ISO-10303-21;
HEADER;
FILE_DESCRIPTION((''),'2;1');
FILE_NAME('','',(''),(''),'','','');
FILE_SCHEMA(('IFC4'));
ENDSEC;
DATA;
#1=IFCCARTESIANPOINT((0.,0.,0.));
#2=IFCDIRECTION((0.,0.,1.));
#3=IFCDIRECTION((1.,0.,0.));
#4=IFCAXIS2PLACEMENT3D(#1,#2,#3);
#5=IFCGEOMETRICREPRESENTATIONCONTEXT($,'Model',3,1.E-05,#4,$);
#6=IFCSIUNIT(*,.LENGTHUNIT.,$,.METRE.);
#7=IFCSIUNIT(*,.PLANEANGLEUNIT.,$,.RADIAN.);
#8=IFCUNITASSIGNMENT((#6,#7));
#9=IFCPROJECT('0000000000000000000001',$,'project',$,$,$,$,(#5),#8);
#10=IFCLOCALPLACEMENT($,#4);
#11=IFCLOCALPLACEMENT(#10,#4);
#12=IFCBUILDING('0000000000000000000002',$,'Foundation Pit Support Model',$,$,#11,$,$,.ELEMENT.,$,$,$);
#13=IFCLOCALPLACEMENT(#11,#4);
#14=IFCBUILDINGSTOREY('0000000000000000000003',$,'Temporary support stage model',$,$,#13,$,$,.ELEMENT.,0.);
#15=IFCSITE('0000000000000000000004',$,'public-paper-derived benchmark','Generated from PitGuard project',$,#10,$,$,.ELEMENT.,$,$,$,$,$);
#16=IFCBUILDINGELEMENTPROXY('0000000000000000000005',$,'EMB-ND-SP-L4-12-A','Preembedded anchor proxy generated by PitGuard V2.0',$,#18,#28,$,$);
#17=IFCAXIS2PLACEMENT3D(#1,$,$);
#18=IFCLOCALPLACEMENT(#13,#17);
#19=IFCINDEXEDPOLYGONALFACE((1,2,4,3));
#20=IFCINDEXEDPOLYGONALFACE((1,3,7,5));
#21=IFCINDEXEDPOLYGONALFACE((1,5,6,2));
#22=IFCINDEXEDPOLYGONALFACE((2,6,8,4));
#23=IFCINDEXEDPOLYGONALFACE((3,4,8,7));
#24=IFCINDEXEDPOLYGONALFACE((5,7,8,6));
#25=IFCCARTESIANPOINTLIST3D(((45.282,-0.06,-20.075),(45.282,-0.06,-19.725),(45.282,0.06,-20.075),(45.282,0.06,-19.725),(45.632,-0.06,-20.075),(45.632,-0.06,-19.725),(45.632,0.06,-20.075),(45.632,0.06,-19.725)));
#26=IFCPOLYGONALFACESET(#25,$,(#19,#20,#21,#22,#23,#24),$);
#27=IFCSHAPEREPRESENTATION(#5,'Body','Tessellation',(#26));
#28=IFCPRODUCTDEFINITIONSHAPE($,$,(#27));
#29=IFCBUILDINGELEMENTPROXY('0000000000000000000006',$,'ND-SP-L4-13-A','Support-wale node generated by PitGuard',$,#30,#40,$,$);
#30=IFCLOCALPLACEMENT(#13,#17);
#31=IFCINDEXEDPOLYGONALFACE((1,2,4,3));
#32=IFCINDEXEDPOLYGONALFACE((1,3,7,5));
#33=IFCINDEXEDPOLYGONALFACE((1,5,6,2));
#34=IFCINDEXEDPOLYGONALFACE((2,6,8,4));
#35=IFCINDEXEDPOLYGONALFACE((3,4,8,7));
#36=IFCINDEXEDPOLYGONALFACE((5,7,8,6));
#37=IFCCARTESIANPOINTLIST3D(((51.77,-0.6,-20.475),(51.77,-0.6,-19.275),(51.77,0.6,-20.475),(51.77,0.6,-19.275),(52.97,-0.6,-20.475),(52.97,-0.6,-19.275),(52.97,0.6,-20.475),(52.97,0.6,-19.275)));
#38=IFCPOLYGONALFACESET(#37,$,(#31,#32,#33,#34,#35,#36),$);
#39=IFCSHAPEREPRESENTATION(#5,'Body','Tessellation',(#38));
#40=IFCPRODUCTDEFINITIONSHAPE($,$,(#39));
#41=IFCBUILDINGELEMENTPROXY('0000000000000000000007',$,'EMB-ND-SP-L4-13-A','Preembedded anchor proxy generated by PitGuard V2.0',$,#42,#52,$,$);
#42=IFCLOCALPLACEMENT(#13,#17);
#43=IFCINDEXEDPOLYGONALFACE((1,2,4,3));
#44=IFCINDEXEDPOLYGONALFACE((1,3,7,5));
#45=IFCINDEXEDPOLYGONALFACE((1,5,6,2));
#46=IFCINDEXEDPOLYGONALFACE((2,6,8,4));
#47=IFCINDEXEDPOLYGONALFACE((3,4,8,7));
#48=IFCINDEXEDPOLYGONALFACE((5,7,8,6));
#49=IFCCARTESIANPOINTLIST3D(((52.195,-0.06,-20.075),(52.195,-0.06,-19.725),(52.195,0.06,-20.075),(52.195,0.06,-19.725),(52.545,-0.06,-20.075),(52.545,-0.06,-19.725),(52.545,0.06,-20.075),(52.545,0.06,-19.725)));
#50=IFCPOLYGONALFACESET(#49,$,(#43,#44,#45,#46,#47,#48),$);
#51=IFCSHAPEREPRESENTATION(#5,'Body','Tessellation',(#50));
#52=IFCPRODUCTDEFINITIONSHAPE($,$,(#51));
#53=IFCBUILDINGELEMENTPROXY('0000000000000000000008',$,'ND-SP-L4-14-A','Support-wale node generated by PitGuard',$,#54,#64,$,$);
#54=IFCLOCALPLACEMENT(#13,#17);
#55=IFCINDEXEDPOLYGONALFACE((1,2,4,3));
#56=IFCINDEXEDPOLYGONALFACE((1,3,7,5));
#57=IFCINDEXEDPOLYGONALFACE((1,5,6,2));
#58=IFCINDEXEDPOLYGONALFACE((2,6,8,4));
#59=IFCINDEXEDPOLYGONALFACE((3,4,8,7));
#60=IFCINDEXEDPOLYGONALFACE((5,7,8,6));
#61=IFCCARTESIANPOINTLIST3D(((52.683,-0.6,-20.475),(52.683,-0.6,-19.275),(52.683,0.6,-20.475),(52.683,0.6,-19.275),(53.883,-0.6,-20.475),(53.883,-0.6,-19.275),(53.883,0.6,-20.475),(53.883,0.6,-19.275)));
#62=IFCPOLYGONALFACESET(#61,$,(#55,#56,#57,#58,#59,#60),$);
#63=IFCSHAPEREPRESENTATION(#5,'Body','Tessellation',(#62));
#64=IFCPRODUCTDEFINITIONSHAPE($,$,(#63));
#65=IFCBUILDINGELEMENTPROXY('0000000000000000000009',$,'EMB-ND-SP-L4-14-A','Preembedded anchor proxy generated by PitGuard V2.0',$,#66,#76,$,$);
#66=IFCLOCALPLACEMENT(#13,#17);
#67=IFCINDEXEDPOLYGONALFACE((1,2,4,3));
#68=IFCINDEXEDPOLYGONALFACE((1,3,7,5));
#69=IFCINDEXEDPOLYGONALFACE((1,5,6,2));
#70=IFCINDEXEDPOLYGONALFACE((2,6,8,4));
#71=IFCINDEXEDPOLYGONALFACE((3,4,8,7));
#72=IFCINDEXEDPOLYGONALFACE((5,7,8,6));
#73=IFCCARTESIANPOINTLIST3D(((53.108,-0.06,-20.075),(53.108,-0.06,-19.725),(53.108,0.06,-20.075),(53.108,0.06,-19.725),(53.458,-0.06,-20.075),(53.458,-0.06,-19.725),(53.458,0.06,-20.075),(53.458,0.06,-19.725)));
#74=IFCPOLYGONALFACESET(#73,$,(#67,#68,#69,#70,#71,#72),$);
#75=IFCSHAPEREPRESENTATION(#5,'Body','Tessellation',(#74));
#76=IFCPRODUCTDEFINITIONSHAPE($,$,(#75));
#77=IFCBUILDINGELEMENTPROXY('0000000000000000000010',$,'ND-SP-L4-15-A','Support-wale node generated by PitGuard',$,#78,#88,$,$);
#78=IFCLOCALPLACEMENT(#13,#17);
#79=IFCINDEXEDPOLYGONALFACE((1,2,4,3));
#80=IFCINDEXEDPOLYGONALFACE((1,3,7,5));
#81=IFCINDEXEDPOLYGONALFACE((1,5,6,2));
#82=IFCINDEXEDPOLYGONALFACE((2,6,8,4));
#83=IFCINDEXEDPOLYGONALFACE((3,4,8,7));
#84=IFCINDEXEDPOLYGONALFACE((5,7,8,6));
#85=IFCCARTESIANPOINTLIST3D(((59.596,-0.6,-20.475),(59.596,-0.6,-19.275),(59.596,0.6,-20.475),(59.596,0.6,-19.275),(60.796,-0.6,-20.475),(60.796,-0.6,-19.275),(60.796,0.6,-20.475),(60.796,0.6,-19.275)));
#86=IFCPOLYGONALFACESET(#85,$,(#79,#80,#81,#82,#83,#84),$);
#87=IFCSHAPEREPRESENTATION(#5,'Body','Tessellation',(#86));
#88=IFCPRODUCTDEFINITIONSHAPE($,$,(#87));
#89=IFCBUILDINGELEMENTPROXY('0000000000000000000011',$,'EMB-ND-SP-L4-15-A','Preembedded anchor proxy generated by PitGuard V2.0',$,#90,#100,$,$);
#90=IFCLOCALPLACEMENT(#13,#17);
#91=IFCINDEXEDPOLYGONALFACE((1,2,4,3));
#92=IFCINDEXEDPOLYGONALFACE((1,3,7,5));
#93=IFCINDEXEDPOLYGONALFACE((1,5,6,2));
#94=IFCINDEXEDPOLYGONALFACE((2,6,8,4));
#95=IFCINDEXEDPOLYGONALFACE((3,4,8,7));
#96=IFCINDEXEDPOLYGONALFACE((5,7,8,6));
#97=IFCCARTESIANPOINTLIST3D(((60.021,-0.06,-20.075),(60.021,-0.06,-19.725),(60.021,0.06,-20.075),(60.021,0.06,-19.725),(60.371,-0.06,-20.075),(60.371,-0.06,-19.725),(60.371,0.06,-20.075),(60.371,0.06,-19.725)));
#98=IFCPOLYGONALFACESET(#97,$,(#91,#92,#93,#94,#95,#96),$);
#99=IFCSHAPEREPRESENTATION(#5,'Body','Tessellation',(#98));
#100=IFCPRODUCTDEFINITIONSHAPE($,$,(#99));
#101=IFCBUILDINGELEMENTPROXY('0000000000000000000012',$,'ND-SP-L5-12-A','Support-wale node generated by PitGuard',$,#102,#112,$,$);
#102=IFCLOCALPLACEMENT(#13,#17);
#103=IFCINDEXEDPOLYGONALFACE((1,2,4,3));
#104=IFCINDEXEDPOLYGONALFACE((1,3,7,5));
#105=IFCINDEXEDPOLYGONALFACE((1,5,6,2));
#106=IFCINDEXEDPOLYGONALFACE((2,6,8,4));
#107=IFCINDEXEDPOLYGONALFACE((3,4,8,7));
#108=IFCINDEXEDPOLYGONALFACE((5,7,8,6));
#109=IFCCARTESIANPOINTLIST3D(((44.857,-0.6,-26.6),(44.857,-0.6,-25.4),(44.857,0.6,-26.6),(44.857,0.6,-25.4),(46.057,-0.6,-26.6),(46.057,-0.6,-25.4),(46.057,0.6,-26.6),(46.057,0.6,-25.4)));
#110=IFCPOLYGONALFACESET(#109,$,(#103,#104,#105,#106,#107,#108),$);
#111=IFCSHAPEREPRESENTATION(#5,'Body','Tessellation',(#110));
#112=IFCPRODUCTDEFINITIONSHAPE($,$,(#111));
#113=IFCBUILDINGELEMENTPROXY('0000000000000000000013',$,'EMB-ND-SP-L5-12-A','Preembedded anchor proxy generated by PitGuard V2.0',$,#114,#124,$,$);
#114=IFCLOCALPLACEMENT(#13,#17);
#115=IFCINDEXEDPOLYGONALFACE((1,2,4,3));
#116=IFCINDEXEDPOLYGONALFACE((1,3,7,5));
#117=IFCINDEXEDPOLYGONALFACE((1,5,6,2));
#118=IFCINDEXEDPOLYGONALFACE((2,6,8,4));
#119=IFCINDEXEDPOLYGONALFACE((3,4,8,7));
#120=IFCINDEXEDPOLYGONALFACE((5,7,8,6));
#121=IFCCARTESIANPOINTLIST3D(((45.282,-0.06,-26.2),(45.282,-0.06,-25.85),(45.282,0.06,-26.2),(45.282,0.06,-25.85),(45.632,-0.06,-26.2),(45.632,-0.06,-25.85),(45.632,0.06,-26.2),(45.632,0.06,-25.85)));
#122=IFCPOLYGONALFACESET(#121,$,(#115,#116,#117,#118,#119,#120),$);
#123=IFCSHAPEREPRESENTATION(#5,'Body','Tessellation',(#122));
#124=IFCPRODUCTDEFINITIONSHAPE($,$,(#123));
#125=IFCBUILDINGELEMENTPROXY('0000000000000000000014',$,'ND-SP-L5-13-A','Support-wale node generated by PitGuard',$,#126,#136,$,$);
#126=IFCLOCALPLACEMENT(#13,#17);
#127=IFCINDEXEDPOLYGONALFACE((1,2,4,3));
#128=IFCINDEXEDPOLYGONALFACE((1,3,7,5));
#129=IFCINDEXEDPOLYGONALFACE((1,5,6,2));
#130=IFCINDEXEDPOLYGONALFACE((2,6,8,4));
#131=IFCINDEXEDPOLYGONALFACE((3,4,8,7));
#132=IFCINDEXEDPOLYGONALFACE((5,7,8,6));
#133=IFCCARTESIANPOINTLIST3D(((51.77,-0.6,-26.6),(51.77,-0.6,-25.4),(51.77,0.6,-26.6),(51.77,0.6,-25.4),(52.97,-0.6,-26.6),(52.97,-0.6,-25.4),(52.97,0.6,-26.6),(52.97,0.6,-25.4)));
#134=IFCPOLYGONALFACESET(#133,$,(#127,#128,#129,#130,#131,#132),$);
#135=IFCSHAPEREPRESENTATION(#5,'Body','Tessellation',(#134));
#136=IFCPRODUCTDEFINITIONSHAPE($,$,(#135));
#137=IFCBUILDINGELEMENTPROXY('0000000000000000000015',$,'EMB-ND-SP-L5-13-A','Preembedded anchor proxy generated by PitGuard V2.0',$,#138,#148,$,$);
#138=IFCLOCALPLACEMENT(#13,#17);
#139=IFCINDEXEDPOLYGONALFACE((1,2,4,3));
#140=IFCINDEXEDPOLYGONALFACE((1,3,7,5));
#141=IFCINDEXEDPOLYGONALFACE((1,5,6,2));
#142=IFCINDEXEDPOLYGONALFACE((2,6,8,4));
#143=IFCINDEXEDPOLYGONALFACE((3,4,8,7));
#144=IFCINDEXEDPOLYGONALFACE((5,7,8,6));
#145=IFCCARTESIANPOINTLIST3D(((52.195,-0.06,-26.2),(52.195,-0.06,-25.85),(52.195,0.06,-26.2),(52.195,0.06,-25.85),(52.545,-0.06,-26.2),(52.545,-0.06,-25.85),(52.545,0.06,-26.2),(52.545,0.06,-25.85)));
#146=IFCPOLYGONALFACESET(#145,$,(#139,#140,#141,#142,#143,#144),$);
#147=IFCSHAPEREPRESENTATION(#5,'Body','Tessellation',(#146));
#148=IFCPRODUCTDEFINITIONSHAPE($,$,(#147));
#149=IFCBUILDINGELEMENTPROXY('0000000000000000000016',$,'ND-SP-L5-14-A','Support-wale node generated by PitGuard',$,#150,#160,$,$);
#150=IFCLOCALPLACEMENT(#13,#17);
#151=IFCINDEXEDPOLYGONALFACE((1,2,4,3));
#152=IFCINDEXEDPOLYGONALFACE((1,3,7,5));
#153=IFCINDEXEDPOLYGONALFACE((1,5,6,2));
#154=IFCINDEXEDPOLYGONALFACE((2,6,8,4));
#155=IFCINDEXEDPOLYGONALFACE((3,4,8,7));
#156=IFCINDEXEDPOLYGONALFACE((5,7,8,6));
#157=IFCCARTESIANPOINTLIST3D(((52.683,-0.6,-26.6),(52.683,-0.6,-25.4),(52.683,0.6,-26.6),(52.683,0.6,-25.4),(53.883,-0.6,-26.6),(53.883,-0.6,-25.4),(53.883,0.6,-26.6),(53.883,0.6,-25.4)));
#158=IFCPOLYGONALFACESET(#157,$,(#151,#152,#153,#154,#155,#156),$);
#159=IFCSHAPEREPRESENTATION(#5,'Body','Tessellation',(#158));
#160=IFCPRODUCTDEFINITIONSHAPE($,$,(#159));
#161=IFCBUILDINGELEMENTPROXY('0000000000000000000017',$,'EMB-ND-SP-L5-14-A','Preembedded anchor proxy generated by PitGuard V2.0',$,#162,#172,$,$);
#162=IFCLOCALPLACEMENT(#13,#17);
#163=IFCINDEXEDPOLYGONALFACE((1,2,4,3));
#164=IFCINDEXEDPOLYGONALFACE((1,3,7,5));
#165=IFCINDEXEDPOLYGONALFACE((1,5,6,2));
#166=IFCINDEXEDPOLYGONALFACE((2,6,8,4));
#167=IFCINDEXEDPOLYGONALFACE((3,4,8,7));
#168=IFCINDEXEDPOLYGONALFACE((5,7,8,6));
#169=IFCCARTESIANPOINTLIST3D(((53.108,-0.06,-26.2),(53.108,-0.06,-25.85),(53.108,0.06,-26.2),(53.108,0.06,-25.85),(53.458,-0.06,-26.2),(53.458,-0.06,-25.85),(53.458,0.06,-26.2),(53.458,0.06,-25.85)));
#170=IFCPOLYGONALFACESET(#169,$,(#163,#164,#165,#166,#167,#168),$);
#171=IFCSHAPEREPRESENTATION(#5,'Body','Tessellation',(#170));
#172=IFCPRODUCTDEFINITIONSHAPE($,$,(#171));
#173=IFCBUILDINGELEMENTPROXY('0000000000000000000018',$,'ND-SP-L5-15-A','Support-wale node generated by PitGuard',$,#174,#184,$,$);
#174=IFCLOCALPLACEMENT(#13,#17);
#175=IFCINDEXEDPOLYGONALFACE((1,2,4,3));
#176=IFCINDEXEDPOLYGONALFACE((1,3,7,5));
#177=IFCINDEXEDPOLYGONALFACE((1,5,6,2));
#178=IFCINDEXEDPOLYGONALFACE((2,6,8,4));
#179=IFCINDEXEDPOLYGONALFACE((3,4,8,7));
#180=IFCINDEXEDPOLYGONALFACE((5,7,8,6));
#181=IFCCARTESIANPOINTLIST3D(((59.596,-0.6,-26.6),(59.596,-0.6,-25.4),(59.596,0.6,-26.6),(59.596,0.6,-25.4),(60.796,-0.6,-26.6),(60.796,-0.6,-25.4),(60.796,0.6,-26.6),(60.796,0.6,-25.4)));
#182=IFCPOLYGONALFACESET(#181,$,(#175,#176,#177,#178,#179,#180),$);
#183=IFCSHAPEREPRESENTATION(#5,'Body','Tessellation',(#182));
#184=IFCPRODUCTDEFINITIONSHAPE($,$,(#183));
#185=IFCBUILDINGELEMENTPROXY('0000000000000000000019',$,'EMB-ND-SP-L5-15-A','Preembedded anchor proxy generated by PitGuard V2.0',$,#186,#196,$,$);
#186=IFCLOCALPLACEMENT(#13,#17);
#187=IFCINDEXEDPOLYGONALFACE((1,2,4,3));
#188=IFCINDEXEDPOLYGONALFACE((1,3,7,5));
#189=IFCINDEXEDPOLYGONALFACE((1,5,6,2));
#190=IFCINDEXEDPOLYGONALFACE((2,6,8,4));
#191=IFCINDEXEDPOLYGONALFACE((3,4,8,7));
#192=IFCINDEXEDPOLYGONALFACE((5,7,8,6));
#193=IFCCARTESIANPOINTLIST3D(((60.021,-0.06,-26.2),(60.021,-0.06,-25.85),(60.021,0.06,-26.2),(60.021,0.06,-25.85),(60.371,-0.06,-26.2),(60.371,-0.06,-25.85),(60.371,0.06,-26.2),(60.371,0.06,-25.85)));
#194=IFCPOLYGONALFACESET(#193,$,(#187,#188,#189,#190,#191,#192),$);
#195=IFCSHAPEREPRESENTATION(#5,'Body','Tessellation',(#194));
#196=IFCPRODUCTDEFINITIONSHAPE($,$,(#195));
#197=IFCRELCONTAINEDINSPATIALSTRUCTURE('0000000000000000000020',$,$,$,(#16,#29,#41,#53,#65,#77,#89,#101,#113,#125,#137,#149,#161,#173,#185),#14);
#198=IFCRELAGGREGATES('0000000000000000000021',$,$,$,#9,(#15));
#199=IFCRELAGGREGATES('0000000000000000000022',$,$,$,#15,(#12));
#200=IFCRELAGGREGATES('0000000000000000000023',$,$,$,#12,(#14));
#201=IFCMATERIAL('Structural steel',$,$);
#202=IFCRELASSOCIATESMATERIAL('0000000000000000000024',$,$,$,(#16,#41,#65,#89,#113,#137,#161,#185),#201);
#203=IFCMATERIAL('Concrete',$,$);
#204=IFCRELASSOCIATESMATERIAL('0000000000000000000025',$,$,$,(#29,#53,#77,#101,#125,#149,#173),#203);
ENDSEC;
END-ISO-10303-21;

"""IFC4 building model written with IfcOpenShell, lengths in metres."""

from ifc_helpers import new_model, si_unit, frame, origin_with_axes, origin_2d, place, context, project, spatial, rectangle, extrude, material, element, save


model = new_model("IFC4")

# Units and contexts
model_context = context("Model", 3, precision=1e-05, world=origin_with_axes())
ifc_project = project(units=[si_unit("LENGTHUNIT", "METRE"), si_unit("PLANEANGLEUNIT", "RADIAN")], contexts=[model_context])

# Site, building, storey
site_placement = place(None, origin_with_axes())
site = spatial("IfcSite", under=ifc_project, at=site_placement, Name="public-paper-derived benchmark", Description="Generated from PitGuard project", CompositionType="ELEMENT")
building_placement = place(site_placement, origin_with_axes())
building = spatial("IfcBuilding", under=site, at=building_placement, Name="Foundation Pit Support Model", CompositionType="ELEMENT")
storey_placement = place(building_placement, origin_with_axes())
storey = spatial("IfcBuildingStorey", under=building, at=storey_placement, Name="Temporary support stage model", CompositionType="ELEMENT", Elevation=0.0)

# Shared definitions
ifc_material_1 = material(Name="Structural steel")

# Shared definitions
ifc_material_2 = material(Name="Concrete")

# Building element proxies
proxy_1_placement = place(storey_placement, frame((45.457, 0.0, -20.075), z_axis=(0.0, 0.0, 1.0), x_axis=(1.0, 0.0, 0.0)))
element("IfcBuildingElementProxy", 1, at=proxy_1_placement, inside=storey, material=ifc_material_1, Name="EMB-ND-SP-L4-12-A", Description="Preembedded anchor proxy generated by PitGuard V2.0", context=model_context, shape_type="SweptSolid", body=[
    extrude(rectangle(XDim=0.35, YDim=0.12, at=origin_2d()), origin_with_axes(), (0.0, 0.0, 1.0), 0.35),
])
proxy_2_placement = place(storey_placement, frame((52.37, 0.0, -20.475), z_axis=(0.0, 0.0, 1.0), x_axis=(1.0, 0.0, 0.0)))
element("IfcBuildingElementProxy", 2, at=proxy_2_placement, inside=storey, material=ifc_material_2, Name="ND-SP-L4-13-A", Description="Support-wale node generated by PitGuard", context=model_context, shape_type="SweptSolid", body=[
    extrude(rectangle(XDim=1.2, YDim=1.2, at=origin_2d()), origin_with_axes(), (0.0, 0.0, 1.0), 1.2),
])
proxy_3_placement = place(storey_placement, frame((52.37, 0.0, -20.075), z_axis=(0.0, 0.0, 1.0), x_axis=(1.0, 0.0, 0.0)))
element("IfcBuildingElementProxy", 3, at=proxy_3_placement, inside=storey, material=ifc_material_1, Name="EMB-ND-SP-L4-13-A", Description="Preembedded anchor proxy generated by PitGuard V2.0", context=model_context, shape_type="SweptSolid", body=[
    extrude(rectangle(XDim=0.35, YDim=0.12, at=origin_2d()), origin_with_axes(), (0.0, 0.0, 1.0), 0.35),
])
proxy_4_placement = place(storey_placement, frame((53.283, 0.0, -20.475), z_axis=(0.0, 0.0, 1.0), x_axis=(1.0, 0.0, 0.0)))
element("IfcBuildingElementProxy", 4, at=proxy_4_placement, inside=storey, material=ifc_material_2, Name="ND-SP-L4-14-A", Description="Support-wale node generated by PitGuard", context=model_context, shape_type="SweptSolid", body=[
    extrude(rectangle(XDim=1.2, YDim=1.2, at=origin_2d()), origin_with_axes(), (0.0, 0.0, 1.0), 1.2),
])
proxy_5_placement = place(storey_placement, frame((53.283, 0.0, -20.075), z_axis=(0.0, 0.0, 1.0), x_axis=(1.0, 0.0, 0.0)))
element("IfcBuildingElementProxy", 5, at=proxy_5_placement, inside=storey, material=ifc_material_1, Name="EMB-ND-SP-L4-14-A", Description="Preembedded anchor proxy generated by PitGuard V2.0", context=model_context, shape_type="SweptSolid", body=[
    extrude(rectangle(XDim=0.35, YDim=0.12, at=origin_2d()), origin_with_axes(), (0.0, 0.0, 1.0), 0.35),
])
proxy_6_placement = place(storey_placement, frame((60.196, 0.0, -20.475), z_axis=(0.0, 0.0, 1.0), x_axis=(1.0, 0.0, 0.0)))
element("IfcBuildingElementProxy", 6, at=proxy_6_placement, inside=storey, material=ifc_material_2, Name="ND-SP-L4-15-A", Description="Support-wale node generated by PitGuard", context=model_context, shape_type="SweptSolid", body=[
    extrude(rectangle(XDim=1.2, YDim=1.2, at=origin_2d()), origin_with_axes(), (0.0, 0.0, 1.0), 1.2),
])
proxy_7_placement = place(storey_placement, frame((60.196, 0.0, -20.075), z_axis=(0.0, 0.0, 1.0), x_axis=(1.0, 0.0, 0.0)))
element("IfcBuildingElementProxy", 7, at=proxy_7_placement, inside=storey, material=ifc_material_1, Name="EMB-ND-SP-L4-15-A", Description="Preembedded anchor proxy generated by PitGuard V2.0", context=model_context, shape_type="SweptSolid", body=[
    extrude(rectangle(XDim=0.35, YDim=0.12, at=origin_2d()), origin_with_axes(), (0.0, 0.0, 1.0), 0.35),
])
proxy_8_placement = place(storey_placement, frame((45.457, 0.0, -26.6), z_axis=(0.0, 0.0, 1.0), x_axis=(1.0, 0.0, 0.0)))
element("IfcBuildingElementProxy", 8, at=proxy_8_placement, inside=storey, material=ifc_material_2, Name="ND-SP-L5-12-A", Description="Support-wale node generated by PitGuard", context=model_context, shape_type="SweptSolid", body=[
    extrude(rectangle(XDim=1.2, YDim=1.2, at=origin_2d()), origin_with_axes(), (0.0, 0.0, 1.0), 1.2),
])
proxy_9_placement = place(storey_placement, frame((45.457, 0.0, -26.2), z_axis=(0.0, 0.0, 1.0), x_axis=(1.0, 0.0, 0.0)))
element("IfcBuildingElementProxy", 9, at=proxy_9_placement, inside=storey, material=ifc_material_1, Name="EMB-ND-SP-L5-12-A", Description="Preembedded anchor proxy generated by PitGuard V2.0", context=model_context, shape_type="SweptSolid", body=[
    extrude(rectangle(XDim=0.35, YDim=0.12, at=origin_2d()), origin_with_axes(), (0.0, 0.0, 1.0), 0.35),
])
proxy_10_placement = place(storey_placement, frame((52.37, 0.0, -26.6), z_axis=(0.0, 0.0, 1.0), x_axis=(1.0, 0.0, 0.0)))
element("IfcBuildingElementProxy", 10, at=proxy_10_placement, inside=storey, material=ifc_material_2, Name="ND-SP-L5-13-A", Description="Support-wale node generated by PitGuard", context=model_context, shape_type="SweptSolid", body=[
    extrude(rectangle(XDim=1.2, YDim=1.2, at=origin_2d()), origin_with_axes(), (0.0, 0.0, 1.0), 1.2),
])
proxy_11_placement = place(storey_placement, frame((52.37, 0.0, -26.2), z_axis=(0.0, 0.0, 1.0), x_axis=(1.0, 0.0, 0.0)))
element("IfcBuildingElementProxy", 11, at=proxy_11_placement, inside=storey, material=ifc_material_1, Name="EMB-ND-SP-L5-13-A", Description="Preembedded anchor proxy generated by PitGuard V2.0", context=model_context, shape_type="SweptSolid", body=[
    extrude(rectangle(XDim=0.35, YDim=0.12, at=origin_2d()), origin_with_axes(), (0.0, 0.0, 1.0), 0.35),
])
proxy_12_placement = place(storey_placement, frame((53.283, 0.0, -26.6), z_axis=(0.0, 0.0, 1.0), x_axis=(1.0, 0.0, 0.0)))
element("IfcBuildingElementProxy", 12, at=proxy_12_placement, inside=storey, material=ifc_material_2, Name="ND-SP-L5-14-A", Description="Support-wale node generated by PitGuard", context=model_context, shape_type="SweptSolid", body=[
    extrude(rectangle(XDim=1.2, YDim=1.2, at=origin_2d()), origin_with_axes(), (0.0, 0.0, 1.0), 1.2),
])
proxy_13_placement = place(storey_placement, frame((53.283, 0.0, -26.2), z_axis=(0.0, 0.0, 1.0), x_axis=(1.0, 0.0, 0.0)))
element("IfcBuildingElementProxy", 13, at=proxy_13_placement, inside=storey, material=ifc_material_1, Name="EMB-ND-SP-L5-14-A", Description="Preembedded anchor proxy generated by PitGuard V2.0", context=model_context, shape_type="SweptSolid", body=[
    extrude(rectangle(XDim=0.35, YDim=0.12, at=origin_2d()), origin_with_axes(), (0.0, 0.0, 1.0), 0.35),
])
proxy_14_placement = place(storey_placement, frame((60.196, 0.0, -26.6), z_axis=(0.0, 0.0, 1.0), x_axis=(1.0, 0.0, 0.0)))
element("IfcBuildingElementProxy", 14, at=proxy_14_placement, inside=storey, material=ifc_material_2, Name="ND-SP-L5-15-A", Description="Support-wale node generated by PitGuard", context=model_context, shape_type="SweptSolid", body=[
    extrude(rectangle(XDim=1.2, YDim=1.2, at=origin_2d()), origin_with_axes(), (0.0, 0.0, 1.0), 1.2),
])
proxy_15_placement = place(storey_placement, frame((60.196, 0.0, -26.2), z_axis=(0.0, 0.0, 1.0), x_axis=(1.0, 0.0, 0.0)))
element("IfcBuildingElementProxy", 15, at=proxy_15_placement, inside=storey, material=ifc_material_1, Name="EMB-ND-SP-L5-15-A", Description="Preembedded anchor proxy generated by PitGuard V2.0", context=model_context, shape_type="SweptSolid", body=[
    extrude(rectangle(XDim=0.35, YDim=0.12, at=origin_2d()), origin_with_axes(), (0.0, 0.0, 1.0), 0.35),
])

save(model, "model.ifc")
